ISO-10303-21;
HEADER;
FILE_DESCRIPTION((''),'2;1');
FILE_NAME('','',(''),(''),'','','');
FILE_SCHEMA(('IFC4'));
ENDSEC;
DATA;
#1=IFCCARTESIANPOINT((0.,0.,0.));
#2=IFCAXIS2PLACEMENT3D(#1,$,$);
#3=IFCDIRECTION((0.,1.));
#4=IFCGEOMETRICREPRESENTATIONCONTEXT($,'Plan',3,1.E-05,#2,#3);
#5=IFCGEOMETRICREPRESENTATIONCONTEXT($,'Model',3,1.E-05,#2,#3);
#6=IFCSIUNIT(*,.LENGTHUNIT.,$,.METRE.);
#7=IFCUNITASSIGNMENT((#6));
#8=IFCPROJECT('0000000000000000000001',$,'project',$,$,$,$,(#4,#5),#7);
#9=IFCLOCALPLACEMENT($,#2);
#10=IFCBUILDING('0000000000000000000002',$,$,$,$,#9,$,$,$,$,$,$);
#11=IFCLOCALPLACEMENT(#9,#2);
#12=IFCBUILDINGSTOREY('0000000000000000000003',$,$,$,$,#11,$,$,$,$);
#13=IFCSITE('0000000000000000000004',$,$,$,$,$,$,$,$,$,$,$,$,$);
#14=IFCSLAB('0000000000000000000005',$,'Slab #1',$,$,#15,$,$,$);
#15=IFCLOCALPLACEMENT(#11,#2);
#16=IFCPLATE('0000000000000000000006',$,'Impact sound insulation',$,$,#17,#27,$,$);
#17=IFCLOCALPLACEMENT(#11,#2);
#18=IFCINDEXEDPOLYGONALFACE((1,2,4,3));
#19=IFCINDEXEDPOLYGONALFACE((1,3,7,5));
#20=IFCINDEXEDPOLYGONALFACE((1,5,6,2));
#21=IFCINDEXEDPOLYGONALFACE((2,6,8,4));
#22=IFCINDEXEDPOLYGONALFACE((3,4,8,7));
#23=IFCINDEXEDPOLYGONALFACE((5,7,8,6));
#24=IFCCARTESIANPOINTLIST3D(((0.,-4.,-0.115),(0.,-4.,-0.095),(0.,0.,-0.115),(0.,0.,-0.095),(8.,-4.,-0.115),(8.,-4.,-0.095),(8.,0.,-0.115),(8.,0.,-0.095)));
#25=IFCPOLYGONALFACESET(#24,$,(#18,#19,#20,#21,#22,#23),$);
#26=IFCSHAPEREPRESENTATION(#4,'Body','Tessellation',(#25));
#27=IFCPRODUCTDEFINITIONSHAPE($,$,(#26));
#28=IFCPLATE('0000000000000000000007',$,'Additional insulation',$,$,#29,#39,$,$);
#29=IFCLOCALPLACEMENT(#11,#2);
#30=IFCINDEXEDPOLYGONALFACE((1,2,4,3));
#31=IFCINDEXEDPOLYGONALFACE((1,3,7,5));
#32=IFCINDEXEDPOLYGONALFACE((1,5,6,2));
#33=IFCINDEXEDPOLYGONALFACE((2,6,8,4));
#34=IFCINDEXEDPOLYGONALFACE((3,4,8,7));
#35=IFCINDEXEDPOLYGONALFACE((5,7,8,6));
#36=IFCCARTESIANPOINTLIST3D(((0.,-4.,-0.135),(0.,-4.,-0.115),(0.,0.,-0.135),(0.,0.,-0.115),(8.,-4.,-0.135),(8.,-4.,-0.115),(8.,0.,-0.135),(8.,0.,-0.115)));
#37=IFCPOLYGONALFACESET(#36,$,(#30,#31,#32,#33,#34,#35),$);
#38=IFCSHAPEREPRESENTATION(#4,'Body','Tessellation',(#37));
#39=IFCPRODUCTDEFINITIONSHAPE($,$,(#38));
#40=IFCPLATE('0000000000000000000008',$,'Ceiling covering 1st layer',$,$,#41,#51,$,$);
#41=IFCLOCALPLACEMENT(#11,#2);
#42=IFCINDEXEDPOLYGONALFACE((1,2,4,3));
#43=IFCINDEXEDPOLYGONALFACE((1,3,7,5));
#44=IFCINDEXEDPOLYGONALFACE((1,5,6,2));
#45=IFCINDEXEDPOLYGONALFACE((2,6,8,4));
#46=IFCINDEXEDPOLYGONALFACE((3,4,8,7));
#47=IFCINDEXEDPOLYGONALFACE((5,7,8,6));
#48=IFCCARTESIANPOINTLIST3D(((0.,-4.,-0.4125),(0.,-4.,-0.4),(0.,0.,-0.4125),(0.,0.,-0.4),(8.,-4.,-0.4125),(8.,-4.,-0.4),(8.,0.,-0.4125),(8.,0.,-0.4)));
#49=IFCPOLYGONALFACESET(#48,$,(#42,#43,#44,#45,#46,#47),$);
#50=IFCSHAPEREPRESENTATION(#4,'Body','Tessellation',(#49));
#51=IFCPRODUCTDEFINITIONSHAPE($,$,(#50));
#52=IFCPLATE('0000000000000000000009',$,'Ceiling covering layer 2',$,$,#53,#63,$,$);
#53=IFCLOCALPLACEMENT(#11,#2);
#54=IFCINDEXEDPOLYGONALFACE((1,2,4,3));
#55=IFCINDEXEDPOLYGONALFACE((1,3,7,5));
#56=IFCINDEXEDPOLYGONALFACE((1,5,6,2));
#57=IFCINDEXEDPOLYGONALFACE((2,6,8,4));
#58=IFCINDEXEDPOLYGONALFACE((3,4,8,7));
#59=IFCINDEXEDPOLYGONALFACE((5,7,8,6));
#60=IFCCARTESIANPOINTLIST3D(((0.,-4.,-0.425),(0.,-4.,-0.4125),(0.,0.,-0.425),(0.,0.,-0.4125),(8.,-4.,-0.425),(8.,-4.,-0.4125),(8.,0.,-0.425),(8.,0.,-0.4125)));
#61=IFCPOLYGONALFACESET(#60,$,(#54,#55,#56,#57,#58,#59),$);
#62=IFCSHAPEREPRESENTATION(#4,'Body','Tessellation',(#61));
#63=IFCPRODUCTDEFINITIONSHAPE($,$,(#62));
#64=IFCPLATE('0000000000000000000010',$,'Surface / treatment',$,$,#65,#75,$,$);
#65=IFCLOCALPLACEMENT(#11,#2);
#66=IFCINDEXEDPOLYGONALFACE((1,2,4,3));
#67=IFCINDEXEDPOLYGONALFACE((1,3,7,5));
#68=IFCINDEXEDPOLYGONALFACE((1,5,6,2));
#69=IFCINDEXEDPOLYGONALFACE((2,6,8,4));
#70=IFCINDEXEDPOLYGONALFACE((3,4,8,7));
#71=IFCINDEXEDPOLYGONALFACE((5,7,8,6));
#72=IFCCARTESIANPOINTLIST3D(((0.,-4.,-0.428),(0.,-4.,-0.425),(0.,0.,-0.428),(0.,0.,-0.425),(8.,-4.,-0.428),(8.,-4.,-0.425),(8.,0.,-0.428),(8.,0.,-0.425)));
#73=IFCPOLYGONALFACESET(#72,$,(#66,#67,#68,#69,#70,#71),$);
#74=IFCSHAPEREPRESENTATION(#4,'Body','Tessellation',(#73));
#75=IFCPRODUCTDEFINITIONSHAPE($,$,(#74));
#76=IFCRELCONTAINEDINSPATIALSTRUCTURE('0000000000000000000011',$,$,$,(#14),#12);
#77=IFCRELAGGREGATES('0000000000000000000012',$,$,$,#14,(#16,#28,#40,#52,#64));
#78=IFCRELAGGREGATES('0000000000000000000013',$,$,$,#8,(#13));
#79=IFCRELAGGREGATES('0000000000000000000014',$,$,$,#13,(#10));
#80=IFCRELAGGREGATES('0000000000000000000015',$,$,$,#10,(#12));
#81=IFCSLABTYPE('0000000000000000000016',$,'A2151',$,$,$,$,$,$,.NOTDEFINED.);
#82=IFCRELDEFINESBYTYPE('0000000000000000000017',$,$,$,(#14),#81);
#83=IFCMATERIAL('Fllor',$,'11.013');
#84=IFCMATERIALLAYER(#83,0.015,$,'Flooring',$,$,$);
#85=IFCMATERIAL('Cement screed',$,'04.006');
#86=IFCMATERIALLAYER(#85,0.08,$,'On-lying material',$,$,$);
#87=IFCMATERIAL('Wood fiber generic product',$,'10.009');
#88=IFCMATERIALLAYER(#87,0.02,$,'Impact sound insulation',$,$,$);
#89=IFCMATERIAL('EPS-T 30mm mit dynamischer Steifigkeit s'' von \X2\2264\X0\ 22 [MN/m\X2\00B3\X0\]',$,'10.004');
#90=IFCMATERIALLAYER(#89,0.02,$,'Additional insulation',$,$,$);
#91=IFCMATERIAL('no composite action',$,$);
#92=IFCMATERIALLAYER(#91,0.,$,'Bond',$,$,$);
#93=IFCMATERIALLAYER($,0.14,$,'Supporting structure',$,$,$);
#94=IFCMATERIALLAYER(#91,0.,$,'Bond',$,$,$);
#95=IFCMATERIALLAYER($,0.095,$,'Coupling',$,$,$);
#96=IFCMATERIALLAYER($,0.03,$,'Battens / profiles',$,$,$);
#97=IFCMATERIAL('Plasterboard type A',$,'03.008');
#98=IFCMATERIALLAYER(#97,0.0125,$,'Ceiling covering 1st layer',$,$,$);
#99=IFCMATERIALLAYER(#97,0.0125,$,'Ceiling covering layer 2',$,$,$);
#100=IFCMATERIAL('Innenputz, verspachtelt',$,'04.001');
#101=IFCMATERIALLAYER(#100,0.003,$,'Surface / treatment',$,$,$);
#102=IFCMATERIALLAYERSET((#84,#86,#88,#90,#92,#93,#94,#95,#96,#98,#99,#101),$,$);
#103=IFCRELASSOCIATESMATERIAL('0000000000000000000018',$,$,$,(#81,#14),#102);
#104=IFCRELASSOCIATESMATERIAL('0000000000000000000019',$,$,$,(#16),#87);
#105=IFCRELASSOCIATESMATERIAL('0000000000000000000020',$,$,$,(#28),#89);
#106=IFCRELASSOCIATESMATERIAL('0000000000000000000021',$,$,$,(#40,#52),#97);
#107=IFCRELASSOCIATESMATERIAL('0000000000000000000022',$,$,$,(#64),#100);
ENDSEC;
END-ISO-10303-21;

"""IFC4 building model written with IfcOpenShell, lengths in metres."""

from ifc_helpers import new_model, si_unit, direction, frame, frame_2d, origin, place, context, project, spatial, rectangle, extrude, material, layer, layer_set, type_object, element, aggregate, save


model = new_model("IFC4")

# Units and contexts
plan_context = context("Plan", 3, precision=1e-05, world=origin(), true_north=direction((0.0, 1.0)))
model_context = context("Model", 3, precision=1e-05, world=origin(), true_north=direction((0.0, 1.0)))
ifc_project = project(units=[si_unit("LENGTHUNIT", "METRE")], contexts=[plan_context, model_context])

# Site, building, storey
site = spatial("IfcSite", under=ifc_project)
building_placement = place(None, origin())
building = spatial("IfcBuilding", under=site, at=building_placement)
storey_placement = place(building_placement, origin())
storey = spatial("IfcBuildingStorey", under=building, at=storey_placement)

# Slab, plates
ifc_material_1 = material(Name="Fllor", Category="11.013")
ifc_layer_1 = layer(ifc_material_1, 0.015, Name="Flooring")
ifc_material_2 = material(Name="Cement screed", Category="04.006")
ifc_layer_2 = layer(ifc_material_2, 0.08, Name="On-lying material")
ifc_material_3 = material(Name="Wood fiber generic product", Category="10.009")
ifc_layer_3 = layer(ifc_material_3, 0.02, Name="Impact sound insulation")
ifc_material_4 = material(Name="EPS-T 30mm mit dynamischer Steifigkeit s' von ≤ 22 [MN/m³]", Category="10.004")
ifc_layer_4 = layer(ifc_material_4, 0.02, Name="Additional insulation")
ifc_material_5 = material(Name="no composite action")
ifc_layer_5 = layer(ifc_material_5, 0.0, Name="Bond")
ifc_layer_6 = layer(None, 0.14, Name="Supporting structure")
ifc_layer_7 = layer(ifc_material_5, 0.0, Name="Bond")
ifc_layer_8 = layer(None, 0.095, Name="Coupling")
ifc_layer_9 = layer(None, 0.03, Name="Battens / profiles")
ifc_material_6 = material(Name="Plasterboard type A", Category="03.008")
ifc_layer_10 = layer(ifc_material_6, 0.0125, Name="Ceiling covering 1st layer")
ifc_layer_11 = layer(ifc_material_6, 0.0125, Name="Ceiling covering layer 2")
ifc_material_7 = material(Name="Innenputz, verspachtelt", Category="04.001")
ifc_layer_12 = layer(ifc_material_7, 0.003, Name="Surface / treatment")
ifc_layer_set = layer_set([ifc_layer_1, ifc_layer_2, ifc_layer_3, ifc_layer_4, ifc_layer_5, ifc_layer_6, ifc_layer_7, ifc_layer_8, ifc_layer_9, ifc_layer_10, ifc_layer_11, ifc_layer_12])
slab_type = type_object("IfcSlabType", Name="A2151", PredefinedType="NOTDEFINED", material=ifc_layer_set)
slab_placement = place(None, frame((0.0, 0.0, 0.0), z_axis=(0.0, 0.0, -1.0), x_axis=(1.0, 0.0, 0.0)))
slab = element("IfcSlab", 1, at=slab_placement, inside=storey, type_object=slab_type, material=ifc_layer_set, Name="Slab #1")
plate_1_placement = place(slab_placement, origin())
plate_1 = element("IfcPlate", 2, at=plate_1_placement, material=ifc_material_3, Name="Impact sound insulation", context=plan_context, shape_type="SweptSolid", body=[
    extrude(rectangle(XDim=8.0, YDim=4.0, at=frame_2d((4.0, 2.0), x_axis=(1.0, 0.0))), frame((0.0, 0.0, 0.095), z_axis=(0.0, 0.0, 1.0), x_axis=(1.0, 0.0, 0.0)), (0.0, 0.0, 1.0), 0.02),
])
plate_2_placement = place(slab_placement, origin())
plate_2 = element("IfcPlate", 3, at=plate_2_placement, material=ifc_material_4, Name="Additional insulation", context=plan_context, shape_type="SweptSolid", body=[
    extrude(rectangle(XDim=8.0, YDim=4.0, at=frame_2d((4.0, 2.0), x_axis=(1.0, 0.0))), frame((0.0, 0.0, 0.115), z_axis=(0.0, 0.0, 1.0), x_axis=(1.0, 0.0, 0.0)), (0.0, 0.0, 1.0), 0.02),
])
plate_3_placement = place(slab_placement, origin())
plate_3 = element("IfcPlate", 4, at=plate_3_placement, material=ifc_material_6, Name="Ceiling covering 1st layer", context=plan_context, shape_type="SweptSolid", body=[
    extrude(rectangle(XDim=8.0, YDim=4.0, at=frame_2d((4.0, 2.0), x_axis=(1.0, 0.0))), frame((0.0, 0.0, 0.4), z_axis=(0.0, 0.0, 1.0), x_axis=(1.0, 0.0, 0.0)), (0.0, 0.0, 1.0), 0.0125),
])
plate_4_placement = place(slab_placement, origin())
plate_4 = element("IfcPlate", 5, at=plate_4_placement, material=ifc_material_6, Name="Ceiling covering layer 2", context=plan_context, shape_type="SweptSolid", body=[
    extrude(rectangle(XDim=8.0, YDim=4.0, at=frame_2d((4.0, 2.0), x_axis=(1.0, 0.0))), frame((0.0, 0.0, 0.4125), z_axis=(0.0, 0.0, 1.0), x_axis=(1.0, 0.0, 0.0)), (0.0, 0.0, 1.0), 0.0125),
])
plate_5_placement = place(slab_placement, origin())
plate_5 = element("IfcPlate", 6, at=plate_5_placement, material=ifc_material_7, Name="Surface / treatment", context=plan_context, shape_type="SweptSolid", body=[
    extrude(rectangle(XDim=8.0, YDim=4.0, at=frame_2d((4.0, 2.0), x_axis=(1.0, 0.0))), frame((0.0, 0.0, 0.425), z_axis=(0.0, 0.0, 1.0), x_axis=(1.0, 0.0, 0.0)), (0.0, 0.0, 1.0), 0.003),
])
aggregate(slab, [plate_1, plate_2, plate_3, plate_4, plate_5])

save(model, "model.ifc")
